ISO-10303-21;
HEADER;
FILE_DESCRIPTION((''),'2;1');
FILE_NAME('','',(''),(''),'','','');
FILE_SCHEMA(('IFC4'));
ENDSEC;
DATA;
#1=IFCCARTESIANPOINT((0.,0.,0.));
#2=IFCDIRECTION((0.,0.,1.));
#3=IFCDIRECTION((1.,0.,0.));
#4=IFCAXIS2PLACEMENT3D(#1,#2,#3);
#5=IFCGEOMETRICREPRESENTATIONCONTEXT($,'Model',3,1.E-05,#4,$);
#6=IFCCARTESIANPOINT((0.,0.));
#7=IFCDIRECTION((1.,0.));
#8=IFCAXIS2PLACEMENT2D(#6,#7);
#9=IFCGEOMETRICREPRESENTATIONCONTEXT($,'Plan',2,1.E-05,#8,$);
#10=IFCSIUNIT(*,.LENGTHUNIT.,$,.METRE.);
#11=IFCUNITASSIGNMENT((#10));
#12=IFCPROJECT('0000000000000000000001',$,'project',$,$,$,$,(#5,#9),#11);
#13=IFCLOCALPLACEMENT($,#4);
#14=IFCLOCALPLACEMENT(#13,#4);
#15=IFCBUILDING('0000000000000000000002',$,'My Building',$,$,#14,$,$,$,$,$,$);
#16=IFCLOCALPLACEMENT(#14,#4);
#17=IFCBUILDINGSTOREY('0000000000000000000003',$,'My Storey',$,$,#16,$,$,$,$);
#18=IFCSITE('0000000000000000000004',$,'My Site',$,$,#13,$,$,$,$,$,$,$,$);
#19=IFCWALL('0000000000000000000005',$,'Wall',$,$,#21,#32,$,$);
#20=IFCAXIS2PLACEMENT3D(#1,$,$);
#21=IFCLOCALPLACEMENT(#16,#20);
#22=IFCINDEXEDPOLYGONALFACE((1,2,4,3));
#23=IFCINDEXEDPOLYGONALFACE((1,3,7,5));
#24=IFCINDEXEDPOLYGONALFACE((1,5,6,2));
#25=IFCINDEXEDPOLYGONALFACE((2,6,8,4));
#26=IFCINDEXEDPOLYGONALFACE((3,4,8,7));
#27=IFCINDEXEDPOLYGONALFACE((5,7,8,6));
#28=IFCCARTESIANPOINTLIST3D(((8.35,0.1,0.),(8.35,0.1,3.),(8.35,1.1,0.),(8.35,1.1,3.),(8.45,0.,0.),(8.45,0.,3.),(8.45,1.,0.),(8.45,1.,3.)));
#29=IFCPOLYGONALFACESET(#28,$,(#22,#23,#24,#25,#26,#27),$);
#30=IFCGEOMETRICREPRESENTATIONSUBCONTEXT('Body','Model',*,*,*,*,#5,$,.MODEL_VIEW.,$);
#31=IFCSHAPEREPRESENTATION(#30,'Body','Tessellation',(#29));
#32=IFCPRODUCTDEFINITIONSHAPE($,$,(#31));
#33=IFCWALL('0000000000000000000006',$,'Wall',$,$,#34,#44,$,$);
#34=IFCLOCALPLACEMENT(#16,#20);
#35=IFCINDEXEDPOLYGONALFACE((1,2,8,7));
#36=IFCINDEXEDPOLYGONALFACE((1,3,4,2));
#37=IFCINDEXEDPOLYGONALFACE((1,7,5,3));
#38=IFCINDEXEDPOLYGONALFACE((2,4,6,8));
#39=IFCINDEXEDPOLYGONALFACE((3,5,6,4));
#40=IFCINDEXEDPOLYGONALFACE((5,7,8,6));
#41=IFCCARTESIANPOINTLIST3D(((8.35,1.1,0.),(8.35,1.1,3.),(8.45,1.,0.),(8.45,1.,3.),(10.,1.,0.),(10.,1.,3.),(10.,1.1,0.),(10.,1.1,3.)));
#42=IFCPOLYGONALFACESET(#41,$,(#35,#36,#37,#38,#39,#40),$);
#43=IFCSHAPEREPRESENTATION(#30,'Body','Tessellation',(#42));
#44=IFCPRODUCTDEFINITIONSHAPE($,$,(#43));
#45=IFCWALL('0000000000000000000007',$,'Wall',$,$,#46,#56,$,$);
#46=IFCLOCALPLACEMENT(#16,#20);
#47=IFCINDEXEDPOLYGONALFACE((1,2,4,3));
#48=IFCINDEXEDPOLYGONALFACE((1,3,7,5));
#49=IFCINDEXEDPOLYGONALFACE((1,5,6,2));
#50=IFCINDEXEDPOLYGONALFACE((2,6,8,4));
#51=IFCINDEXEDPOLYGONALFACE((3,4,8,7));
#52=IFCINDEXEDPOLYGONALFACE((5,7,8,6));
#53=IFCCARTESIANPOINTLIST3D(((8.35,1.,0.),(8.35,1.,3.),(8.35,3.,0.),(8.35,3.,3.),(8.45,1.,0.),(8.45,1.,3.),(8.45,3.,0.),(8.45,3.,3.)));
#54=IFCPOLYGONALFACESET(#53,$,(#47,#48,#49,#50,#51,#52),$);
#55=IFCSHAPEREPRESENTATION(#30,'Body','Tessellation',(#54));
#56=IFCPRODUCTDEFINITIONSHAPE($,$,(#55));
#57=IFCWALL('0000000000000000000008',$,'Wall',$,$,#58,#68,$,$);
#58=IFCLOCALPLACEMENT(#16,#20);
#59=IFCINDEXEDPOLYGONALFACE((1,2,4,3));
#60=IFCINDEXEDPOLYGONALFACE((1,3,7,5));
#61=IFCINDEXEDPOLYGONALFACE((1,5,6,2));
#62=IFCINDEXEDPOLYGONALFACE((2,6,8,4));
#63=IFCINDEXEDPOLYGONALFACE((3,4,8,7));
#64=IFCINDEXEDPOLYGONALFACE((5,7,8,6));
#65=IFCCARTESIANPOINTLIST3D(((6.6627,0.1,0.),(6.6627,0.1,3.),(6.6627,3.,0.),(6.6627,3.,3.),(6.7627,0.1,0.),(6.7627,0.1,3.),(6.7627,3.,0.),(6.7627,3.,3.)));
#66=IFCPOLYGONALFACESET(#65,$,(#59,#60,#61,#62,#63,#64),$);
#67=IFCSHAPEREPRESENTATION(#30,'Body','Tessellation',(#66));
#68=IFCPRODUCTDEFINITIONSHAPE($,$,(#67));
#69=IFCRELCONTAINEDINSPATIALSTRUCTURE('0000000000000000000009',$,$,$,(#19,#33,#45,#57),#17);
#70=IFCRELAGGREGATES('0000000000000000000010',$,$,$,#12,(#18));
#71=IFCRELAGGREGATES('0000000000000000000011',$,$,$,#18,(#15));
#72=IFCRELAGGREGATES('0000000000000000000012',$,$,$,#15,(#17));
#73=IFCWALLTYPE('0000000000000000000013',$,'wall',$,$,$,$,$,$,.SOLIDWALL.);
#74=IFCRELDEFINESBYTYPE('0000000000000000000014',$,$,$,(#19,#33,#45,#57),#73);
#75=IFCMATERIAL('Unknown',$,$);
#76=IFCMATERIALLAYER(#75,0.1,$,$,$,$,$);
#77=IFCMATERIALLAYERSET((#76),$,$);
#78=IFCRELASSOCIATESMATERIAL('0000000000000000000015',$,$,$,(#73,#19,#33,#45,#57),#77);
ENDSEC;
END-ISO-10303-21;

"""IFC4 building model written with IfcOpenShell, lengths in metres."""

from ifc_helpers import new_model, si_unit, frame, origin_with_axes, origin_2d_with_axis, place, context, subcontext, project, spatial, line, indexed_curve, outline, extrude, material, layer, layer_set, layer_usage, type_object, element, save


model = new_model("IFC4")

# Units and contexts
model_context = context("Model", 3, precision=1e-05, world=origin_with_axes())
plan_context = context("Plan", 2, precision=1e-05, world=origin_2d_with_axis())
body_context_1 = subcontext(model_context, "Body", "Model", "MODEL_VIEW")
ifc_project = project(units=[si_unit("LENGTHUNIT", "METRE")], contexts=[model_context, plan_context])

# Site, building, storey
site_placement = place(None, origin_with_axes())
site = spatial("IfcSite", under=ifc_project, at=site_placement, Name="My Site")
building_placement = place(site_placement, origin_with_axes())
building = spatial("IfcBuilding", under=site, at=building_placement, Name="My Building")
storey_placement = place(building_placement, origin_with_axes())
storey = spatial("IfcBuildingStorey", under=building, at=storey_placement, Name="My Storey")

# Shared definitions
ifc_material = material(Name="Unknown")

# Shared definitions
ifc_layer_1 = layer(ifc_material, 0.1)
ifc_layer_set_1 = layer_set([ifc_layer_1])
wall_type = type_object("IfcWallType", Name="wall", PredefinedType="SOLIDWALL", material=ifc_layer_set_1)

# Walls
ifc_layer_usage_1 = layer_usage(ifc_layer_set_1, "AXIS2", "POSITIVE", 0.0)
wall_1_placement = place(storey_placement, frame((8.45, 0.0, 0.0), z_axis=(0.0, 0.0, 1.0), x_axis=(0.0, 1.0, 0.0)))
element("IfcWall", 1, at=wall_1_placement, inside=storey, type_object=wall_type, material=ifc_layer_usage_1, Name="Wall", context=body_context_1, shape_type="SweptSolid", body=[
    extrude(outline(indexed_curve([(0.0, 0.0), (0.1, 0.1), (1.1, 0.1), (1.0, 0.0)], segments=[line(1, 2, 3, 4, 1)])), origin_with_axes(), (0.0, 0.0, 1.0), 3.0),
])
ifc_layer_usage_2 = layer_usage(ifc_layer_set_1, "AXIS2", "POSITIVE", 0.0)
wall_2_placement = place(storey_placement, frame((8.45, 1.0, 0.0), z_axis=(0.0, 0.0, 1.0), x_axis=(1.0, 0.0, 0.0)))
element("IfcWall", 2, at=wall_2_placement, inside=storey, type_object=wall_type, material=ifc_layer_usage_2, Name="Wall", context=body_context_1, shape_type="SweptSolid", body=[
    extrude(outline(indexed_curve([(0.0, 0.0), (-0.1, 0.1), (1.55, 0.1), (1.55, 0.0)], segments=[line(1, 2, 3, 4, 1)])), origin_with_axes(), (0.0, 0.0, 1.0), 3.0),
])
ifc_layer_usage_3 = layer_usage(ifc_layer_set_1, "AXIS2", "POSITIVE", 0.0)
wall_3_placement = place(storey_placement, frame((8.45, 1.0, 0.0), z_axis=(0.0, 0.0, 1.0), x_axis=(0.0, 1.0, 0.0)))
element("IfcWall", 3, at=wall_3_placement, inside=storey, type_object=wall_type, material=ifc_layer_usage_3, Name="Wall", context=body_context_1, shape_type="SweptSolid", body=[
    extrude(outline(indexed_curve([(0.0, 0.0), (0.0, 0.1), (2.0, 0.1), (2.0, 0.0)], segments=[line(1, 2, 3, 4, 1)])), origin_with_axes(), (0.0, 0.0, 1.0), 3.0),
])
ifc_layer_usage_4 = layer_usage(ifc_layer_set_1, "AXIS2", "POSITIVE", 0.0)
wall_4_placement = place(storey_placement, frame((6.6627, 3.0, 0.0), z_axis=(0.0, 0.0, 1.0), x_axis=(0.0, -1.0, 0.0)))
element("IfcWall", 4, at=wall_4_placement, inside=storey, type_object=wall_type, material=ifc_layer_usage_4, Name="Wall", context=body_context_1, shape_type="SweptSolid", body=[
    extrude(outline(indexed_curve([(0.0, 0.0), (0.0, 0.1), (2.9, 0.1), (2.9, 0.0)], segments=[line(1, 2, 3, 4, 1)])), origin_with_axes(), (0.0, 0.0, 1.0), 3.0),
])

save(model, "model.ifc")
